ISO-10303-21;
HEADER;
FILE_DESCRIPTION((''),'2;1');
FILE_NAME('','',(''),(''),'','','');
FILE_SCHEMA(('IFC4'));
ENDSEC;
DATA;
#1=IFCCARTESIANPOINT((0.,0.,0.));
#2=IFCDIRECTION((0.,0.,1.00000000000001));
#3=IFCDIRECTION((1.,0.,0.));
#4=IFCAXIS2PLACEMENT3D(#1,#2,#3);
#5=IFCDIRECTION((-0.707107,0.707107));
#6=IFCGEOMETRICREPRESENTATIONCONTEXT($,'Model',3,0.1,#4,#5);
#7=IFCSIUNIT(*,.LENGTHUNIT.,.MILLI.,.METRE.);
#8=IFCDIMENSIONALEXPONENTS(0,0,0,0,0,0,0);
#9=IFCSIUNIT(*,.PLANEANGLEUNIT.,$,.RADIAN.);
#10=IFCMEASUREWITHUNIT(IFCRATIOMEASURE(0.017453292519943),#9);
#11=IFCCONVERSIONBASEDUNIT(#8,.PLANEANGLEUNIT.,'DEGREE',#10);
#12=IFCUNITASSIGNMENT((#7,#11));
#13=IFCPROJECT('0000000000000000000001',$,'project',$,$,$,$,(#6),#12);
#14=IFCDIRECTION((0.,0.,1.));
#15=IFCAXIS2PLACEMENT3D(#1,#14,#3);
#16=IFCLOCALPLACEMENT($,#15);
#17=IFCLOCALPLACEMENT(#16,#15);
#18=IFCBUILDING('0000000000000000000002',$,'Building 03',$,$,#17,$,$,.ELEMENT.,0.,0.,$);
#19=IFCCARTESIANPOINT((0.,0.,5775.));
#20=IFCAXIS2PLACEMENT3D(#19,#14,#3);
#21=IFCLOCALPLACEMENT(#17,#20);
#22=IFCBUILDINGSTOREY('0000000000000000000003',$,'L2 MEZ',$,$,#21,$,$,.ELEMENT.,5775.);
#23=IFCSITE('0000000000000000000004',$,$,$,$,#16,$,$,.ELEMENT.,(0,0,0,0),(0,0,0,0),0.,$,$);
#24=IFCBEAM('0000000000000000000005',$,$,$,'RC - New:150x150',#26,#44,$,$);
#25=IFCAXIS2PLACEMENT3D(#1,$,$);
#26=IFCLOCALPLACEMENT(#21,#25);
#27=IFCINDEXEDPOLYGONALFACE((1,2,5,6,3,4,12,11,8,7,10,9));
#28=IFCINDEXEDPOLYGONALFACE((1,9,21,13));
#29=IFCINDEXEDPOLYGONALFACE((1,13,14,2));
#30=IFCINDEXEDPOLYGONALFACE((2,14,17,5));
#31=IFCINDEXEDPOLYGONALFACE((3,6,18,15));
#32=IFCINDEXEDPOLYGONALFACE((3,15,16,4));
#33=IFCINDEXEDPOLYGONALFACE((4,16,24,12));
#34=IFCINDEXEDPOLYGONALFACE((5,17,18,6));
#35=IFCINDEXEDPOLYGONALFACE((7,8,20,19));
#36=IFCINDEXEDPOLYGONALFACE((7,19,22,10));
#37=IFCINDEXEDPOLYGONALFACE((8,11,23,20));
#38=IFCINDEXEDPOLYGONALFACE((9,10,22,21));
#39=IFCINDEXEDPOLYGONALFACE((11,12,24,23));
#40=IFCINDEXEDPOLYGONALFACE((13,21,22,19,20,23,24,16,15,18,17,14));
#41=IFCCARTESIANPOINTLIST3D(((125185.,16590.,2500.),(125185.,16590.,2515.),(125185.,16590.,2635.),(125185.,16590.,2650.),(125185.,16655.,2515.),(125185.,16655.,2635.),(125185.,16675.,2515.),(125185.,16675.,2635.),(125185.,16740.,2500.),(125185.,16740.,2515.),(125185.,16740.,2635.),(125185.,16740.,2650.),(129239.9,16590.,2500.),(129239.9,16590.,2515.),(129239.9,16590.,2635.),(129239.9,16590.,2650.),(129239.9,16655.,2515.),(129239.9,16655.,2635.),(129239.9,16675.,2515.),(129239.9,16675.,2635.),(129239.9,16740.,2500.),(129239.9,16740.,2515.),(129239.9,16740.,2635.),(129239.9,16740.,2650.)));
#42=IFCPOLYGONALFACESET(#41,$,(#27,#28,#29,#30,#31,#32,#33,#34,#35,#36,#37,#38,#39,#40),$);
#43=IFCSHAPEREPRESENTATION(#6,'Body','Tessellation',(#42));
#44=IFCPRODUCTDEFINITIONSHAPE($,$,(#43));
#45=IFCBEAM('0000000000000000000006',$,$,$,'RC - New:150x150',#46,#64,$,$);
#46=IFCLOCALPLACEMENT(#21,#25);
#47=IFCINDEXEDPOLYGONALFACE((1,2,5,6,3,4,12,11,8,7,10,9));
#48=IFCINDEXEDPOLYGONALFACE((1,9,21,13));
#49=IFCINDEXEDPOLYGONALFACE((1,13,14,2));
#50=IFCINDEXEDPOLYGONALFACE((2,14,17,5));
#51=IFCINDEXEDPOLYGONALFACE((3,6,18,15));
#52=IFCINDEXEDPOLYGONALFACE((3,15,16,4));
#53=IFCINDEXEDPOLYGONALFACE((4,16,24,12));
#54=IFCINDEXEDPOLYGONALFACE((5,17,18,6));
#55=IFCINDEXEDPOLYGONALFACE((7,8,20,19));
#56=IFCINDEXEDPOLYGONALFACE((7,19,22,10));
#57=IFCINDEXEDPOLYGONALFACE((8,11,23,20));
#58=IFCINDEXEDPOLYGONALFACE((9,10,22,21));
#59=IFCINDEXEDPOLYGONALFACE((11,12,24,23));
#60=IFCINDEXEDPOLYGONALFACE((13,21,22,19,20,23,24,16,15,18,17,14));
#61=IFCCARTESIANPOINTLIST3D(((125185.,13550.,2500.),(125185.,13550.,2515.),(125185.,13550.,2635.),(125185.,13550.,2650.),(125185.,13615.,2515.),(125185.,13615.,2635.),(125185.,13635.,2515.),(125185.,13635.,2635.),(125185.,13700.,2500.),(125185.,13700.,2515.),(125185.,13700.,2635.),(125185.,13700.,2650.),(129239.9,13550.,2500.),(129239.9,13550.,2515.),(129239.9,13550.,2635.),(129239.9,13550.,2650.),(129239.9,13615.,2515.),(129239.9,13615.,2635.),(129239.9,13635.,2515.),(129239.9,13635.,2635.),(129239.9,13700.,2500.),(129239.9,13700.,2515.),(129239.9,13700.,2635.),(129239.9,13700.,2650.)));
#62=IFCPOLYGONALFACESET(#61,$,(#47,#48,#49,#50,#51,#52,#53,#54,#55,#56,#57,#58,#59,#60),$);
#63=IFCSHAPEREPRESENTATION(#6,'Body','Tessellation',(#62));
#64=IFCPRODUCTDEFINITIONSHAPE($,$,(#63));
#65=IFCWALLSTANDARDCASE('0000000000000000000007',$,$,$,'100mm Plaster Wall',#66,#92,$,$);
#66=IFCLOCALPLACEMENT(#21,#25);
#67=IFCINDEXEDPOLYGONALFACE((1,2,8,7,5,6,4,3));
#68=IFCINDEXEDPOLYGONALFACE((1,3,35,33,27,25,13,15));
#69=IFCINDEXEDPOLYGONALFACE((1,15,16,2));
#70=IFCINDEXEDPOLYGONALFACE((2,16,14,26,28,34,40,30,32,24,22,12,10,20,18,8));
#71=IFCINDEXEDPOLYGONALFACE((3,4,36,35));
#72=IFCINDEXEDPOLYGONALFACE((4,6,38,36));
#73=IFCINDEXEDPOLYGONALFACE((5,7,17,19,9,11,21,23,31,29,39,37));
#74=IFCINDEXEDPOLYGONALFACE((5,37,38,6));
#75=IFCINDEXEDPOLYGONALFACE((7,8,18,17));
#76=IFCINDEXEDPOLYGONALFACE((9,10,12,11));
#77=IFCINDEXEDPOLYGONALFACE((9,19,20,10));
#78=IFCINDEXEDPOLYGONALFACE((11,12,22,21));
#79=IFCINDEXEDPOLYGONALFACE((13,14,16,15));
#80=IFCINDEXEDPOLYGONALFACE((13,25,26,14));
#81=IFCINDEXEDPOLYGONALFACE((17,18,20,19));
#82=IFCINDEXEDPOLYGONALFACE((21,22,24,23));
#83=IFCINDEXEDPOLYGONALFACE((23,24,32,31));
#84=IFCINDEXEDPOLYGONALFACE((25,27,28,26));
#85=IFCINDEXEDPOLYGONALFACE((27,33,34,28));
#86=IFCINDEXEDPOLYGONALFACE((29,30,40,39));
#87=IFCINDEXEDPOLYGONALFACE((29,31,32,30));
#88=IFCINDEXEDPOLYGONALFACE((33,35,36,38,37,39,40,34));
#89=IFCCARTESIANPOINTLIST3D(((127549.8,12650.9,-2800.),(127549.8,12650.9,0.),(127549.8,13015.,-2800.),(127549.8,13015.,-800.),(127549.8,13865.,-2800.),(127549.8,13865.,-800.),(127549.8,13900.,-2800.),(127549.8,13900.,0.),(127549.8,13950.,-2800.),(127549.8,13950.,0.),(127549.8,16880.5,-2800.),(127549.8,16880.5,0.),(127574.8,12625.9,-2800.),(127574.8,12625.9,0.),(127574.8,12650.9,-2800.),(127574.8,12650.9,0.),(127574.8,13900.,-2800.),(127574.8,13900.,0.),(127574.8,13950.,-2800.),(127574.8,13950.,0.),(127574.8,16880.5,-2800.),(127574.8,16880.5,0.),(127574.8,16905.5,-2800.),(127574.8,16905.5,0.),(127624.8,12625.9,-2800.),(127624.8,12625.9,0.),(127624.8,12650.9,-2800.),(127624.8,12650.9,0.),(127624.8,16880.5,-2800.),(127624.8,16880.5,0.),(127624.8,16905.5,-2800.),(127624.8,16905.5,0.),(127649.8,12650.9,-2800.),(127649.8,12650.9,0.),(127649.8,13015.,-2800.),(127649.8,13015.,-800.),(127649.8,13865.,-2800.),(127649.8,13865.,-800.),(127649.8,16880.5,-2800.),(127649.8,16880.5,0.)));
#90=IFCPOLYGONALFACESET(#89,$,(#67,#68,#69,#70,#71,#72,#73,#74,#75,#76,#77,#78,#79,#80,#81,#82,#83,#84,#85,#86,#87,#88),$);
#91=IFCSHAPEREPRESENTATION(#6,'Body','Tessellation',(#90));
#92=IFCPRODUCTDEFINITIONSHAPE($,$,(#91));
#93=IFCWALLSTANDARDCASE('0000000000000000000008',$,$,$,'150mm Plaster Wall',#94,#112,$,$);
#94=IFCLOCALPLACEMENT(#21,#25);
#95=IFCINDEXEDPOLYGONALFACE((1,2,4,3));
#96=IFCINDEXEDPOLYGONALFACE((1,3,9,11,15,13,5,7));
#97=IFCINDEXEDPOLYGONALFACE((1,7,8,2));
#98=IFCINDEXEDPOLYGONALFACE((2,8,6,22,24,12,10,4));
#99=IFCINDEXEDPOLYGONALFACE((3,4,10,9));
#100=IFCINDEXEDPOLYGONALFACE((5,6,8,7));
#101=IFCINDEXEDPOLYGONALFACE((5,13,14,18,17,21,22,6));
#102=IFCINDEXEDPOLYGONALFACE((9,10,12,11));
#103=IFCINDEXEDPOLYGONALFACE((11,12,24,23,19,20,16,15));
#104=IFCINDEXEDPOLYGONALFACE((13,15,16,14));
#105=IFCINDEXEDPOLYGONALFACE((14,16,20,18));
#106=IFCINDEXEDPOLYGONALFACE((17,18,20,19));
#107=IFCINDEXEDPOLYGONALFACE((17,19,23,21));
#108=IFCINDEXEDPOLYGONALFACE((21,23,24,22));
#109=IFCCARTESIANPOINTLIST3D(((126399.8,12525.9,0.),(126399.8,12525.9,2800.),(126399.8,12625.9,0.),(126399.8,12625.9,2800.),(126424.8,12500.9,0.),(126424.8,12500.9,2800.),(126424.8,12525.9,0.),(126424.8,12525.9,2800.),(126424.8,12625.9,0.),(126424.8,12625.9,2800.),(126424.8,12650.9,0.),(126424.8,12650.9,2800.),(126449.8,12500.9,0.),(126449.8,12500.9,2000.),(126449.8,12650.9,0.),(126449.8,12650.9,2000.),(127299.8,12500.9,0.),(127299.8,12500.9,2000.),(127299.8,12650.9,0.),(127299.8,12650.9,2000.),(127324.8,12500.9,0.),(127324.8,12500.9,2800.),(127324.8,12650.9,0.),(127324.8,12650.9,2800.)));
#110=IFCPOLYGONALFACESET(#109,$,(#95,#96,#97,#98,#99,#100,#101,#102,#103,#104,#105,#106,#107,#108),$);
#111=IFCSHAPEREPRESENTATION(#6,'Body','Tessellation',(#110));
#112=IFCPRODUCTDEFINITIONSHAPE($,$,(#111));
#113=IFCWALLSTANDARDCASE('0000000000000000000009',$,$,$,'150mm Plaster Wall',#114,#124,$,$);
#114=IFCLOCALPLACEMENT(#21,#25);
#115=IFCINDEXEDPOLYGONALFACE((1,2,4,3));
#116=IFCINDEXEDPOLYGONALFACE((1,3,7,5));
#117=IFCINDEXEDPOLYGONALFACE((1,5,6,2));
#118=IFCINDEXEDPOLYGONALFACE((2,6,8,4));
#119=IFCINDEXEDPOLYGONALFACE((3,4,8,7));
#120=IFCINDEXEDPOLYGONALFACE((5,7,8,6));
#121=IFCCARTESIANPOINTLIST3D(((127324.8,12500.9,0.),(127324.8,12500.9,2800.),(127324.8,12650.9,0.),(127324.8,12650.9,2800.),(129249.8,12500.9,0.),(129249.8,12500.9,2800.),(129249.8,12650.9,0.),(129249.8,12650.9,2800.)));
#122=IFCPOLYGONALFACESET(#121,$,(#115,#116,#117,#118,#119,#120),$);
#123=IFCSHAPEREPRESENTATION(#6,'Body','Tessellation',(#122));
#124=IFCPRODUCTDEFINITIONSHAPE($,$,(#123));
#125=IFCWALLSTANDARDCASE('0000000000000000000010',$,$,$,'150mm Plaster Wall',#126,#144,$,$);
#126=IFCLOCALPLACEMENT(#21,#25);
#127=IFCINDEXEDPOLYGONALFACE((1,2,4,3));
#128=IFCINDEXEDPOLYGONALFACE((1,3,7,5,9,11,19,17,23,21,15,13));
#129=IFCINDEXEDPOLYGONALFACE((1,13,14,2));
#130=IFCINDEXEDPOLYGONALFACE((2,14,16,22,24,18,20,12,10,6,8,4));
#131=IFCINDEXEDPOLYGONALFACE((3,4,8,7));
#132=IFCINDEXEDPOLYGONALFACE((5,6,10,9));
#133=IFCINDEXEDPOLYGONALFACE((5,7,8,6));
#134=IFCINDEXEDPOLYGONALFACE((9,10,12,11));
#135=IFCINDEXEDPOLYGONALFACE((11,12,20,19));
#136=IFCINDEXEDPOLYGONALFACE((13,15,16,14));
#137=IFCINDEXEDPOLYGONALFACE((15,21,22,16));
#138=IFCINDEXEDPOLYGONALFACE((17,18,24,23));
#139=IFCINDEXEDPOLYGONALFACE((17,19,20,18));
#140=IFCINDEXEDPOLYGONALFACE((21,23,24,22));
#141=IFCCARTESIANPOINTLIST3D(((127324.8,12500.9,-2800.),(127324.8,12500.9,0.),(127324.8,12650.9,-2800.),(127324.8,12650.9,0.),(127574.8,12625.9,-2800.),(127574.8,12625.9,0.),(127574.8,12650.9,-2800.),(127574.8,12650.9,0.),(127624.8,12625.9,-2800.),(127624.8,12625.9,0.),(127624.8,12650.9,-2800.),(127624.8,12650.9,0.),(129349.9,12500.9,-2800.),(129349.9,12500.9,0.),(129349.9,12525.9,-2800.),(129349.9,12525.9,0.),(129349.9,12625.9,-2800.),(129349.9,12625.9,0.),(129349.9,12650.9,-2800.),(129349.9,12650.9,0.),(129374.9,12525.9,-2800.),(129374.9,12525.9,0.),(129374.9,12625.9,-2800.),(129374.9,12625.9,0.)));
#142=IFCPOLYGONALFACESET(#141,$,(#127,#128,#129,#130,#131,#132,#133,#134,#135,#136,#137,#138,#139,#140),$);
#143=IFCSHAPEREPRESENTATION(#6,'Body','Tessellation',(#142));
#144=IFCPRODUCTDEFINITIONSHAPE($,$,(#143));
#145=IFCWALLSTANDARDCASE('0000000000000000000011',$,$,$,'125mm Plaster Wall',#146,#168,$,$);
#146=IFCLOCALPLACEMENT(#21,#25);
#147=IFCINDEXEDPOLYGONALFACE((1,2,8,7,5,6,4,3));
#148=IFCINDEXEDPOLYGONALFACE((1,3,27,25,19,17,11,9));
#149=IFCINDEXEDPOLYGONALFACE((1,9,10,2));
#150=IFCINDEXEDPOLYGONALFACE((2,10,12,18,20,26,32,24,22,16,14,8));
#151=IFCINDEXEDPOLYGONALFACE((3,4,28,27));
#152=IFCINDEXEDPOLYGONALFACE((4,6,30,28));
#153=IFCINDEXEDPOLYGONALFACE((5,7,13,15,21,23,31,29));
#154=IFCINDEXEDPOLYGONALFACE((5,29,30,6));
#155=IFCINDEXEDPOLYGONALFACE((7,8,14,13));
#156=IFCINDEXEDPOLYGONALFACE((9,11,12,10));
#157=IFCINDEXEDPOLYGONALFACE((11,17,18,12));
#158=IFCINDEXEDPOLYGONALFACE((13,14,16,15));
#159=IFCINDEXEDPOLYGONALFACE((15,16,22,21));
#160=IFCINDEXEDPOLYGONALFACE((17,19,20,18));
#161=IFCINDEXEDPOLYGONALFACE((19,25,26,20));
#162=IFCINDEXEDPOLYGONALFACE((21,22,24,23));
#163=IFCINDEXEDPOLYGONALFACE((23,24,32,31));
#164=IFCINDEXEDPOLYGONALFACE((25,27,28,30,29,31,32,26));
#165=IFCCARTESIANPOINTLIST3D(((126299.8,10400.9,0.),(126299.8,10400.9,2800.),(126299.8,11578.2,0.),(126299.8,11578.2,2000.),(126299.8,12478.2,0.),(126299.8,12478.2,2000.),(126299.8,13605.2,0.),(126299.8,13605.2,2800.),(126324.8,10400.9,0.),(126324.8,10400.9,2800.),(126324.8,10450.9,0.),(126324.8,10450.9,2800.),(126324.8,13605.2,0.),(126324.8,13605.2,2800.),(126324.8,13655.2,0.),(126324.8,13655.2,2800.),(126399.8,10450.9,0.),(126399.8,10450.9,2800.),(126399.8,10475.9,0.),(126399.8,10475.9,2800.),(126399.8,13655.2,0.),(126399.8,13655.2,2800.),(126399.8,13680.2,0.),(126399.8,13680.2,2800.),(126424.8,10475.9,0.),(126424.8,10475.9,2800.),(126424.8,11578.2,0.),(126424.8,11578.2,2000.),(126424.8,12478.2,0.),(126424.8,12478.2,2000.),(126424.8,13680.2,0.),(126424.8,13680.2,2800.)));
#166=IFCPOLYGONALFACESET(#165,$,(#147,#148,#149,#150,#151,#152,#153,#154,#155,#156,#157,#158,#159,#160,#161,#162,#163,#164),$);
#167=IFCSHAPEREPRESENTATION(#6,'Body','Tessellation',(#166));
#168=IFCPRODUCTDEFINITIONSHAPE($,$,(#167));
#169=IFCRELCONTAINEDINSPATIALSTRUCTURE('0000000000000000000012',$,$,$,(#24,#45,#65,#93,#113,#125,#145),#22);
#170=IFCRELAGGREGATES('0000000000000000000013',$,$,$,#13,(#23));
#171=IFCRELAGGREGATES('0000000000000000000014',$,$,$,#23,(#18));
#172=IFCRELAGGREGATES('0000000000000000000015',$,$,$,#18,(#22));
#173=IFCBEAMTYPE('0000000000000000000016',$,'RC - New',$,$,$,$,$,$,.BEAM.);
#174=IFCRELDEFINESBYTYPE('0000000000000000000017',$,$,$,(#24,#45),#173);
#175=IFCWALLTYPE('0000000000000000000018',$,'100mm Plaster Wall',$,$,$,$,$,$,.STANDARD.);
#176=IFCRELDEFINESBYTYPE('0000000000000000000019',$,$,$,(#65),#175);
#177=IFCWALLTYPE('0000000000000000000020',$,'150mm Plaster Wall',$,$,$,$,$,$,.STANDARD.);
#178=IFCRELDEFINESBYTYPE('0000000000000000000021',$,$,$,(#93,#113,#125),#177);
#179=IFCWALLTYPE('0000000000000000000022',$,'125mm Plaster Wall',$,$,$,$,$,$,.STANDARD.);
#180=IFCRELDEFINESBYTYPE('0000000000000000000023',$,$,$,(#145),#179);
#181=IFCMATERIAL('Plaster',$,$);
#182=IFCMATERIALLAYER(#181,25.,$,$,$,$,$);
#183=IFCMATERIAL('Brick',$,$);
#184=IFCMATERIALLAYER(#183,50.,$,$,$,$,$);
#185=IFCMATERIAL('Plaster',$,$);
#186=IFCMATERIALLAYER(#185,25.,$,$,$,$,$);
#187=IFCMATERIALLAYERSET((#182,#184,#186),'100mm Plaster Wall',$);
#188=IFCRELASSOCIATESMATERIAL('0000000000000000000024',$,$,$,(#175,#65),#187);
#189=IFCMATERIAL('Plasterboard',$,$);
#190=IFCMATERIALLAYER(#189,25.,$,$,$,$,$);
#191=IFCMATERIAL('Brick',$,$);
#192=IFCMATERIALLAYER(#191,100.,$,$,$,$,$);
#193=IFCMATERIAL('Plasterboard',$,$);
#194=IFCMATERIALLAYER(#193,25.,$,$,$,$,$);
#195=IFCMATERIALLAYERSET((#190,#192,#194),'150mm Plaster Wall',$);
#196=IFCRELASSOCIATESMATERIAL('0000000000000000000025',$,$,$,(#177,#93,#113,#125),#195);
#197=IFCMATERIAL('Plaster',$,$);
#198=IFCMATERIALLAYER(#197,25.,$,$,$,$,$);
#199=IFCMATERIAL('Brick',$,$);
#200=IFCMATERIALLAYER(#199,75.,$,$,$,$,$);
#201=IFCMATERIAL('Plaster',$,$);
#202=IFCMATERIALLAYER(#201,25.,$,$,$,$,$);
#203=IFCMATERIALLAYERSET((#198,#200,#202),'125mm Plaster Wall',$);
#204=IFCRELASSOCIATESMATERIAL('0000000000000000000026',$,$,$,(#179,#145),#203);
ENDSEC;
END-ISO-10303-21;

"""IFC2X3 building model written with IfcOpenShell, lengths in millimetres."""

from ifc_helpers import new_model, entity, si_unit, converted_unit, direction, frame, origin_with_axes, origin_2d, place, context, project, spatial, polyline, rectangle, i_section, outline, extrude, material, layer, layer_set, layer_usage, type_object, element, save


model = new_model("IFC2X3")

# Units and contexts
model_context = context("Model", 3, precision=0.1, world=frame((0.0, 0.0, 0.0), z_axis=(0.0, 0.0, 1.00000000000001), x_axis=(1.0, 0.0, 0.0)), true_north=direction((-0.707107, 0.707107)))
ifc_project = project(units=[si_unit("LENGTHUNIT", "METRE", prefix="MILLI"), converted_unit("PLANEANGLEUNIT", "DEGREE", entity("IfcRatioMeasure", 0.017453292519943), si_unit("PLANEANGLEUNIT", "RADIAN"), dimensions=[0, 0, 0, 0, 0, 0, 0])], contexts=[model_context])

# Site, building, storey
site_placement = place(None, origin_with_axes())
site = spatial("IfcSite", under=ifc_project, at=site_placement, CompositionType="ELEMENT", RefLatitude=(0, 0, 0, 0), RefLongitude=(0, 0, 0, 0), RefElevation=0.0)
building_placement = place(site_placement, origin_with_axes())
building = spatial("IfcBuilding", under=site, at=building_placement, Name="Building 03", CompositionType="ELEMENT", ElevationOfRefHeight=0.0, ElevationOfTerrain=0.0)
storey_placement = place(building_placement, frame((0.0, 0.0, 5775.0), z_axis=(0.0, 0.0, 1.0), x_axis=(1.0, 0.0, 0.0)))
storey = spatial("IfcBuildingStorey", under=building, at=storey_placement, Name="L2 MEZ", CompositionType="ELEMENT", Elevation=5775.0)

# Beams
beam_type = type_object("IfcBeamType", Name="RC - New", PredefinedType="BEAM")
for number, where, z_axis, x_axis in (
    (1, (125185.0, 16665.0, 8350.0), (1.0, 0.0, 0.0), (0.0, 1.0, 0.0)),
    (2, (125185.0, 13625.0, 8350.0), (1.0, 0.0, 0.0), (0.0, 1.0, 0.0)),
):
    element("IfcBeam", number, at=place(site_placement, frame(where, z_axis=z_axis, x_axis=x_axis)), inside=storey, type_object=beam_type, ObjectType="RC - New:150x150", context=model_context, shape_type="SweptSolid", body=[
        extrude(i_section(OverallWidth=150.0, OverallDepth=150.0, WebThickness=20.0, FlangeThickness=15.0, at=origin_2d()), frame((0.0, 0.0, 0.0), z_axis=(0.0, 0.0, 1.0), x_axis=(1.0, 0.0, 0.0)), (0.0, 0.0, 1.0), 4054.9),
    ])

# Wall, opening
ifc_material_1 = material(Name="Plaster")
ifc_layer_1 = layer(ifc_material_1, 25.0)
ifc_material_2 = material(Name="Brick")
ifc_layer_2 = layer(ifc_material_2, 50.0)
ifc_material_3 = material(Name="Plaster")
ifc_layer_3 = layer(ifc_material_3, 25.0)
ifc_layer_set_1 = layer_set([ifc_layer_1, ifc_layer_2, ifc_layer_3], Name="100mm Plaster Wall")
ifc_layer_usage_1 = layer_usage(ifc_layer_set_1, "AXIS2", "POSITIVE", -50.0)
wall_type_1 = type_object("IfcWallType", Name="100mm Plaster Wall", PredefinedType="STANDARD", material=ifc_layer_set_1)
wall_1_placement = place(site_placement, frame((127599.8, 12650.9, 2975.0), z_axis=(0.0, 0.0, 1.0), x_axis=(0.0, 1.0, 0.0)))
wall_1 = element("IfcWallStandardCase", 3, at=wall_1_placement, inside=storey, type_object=wall_type_1, material=ifc_layer_usage_1, ObjectType="100mm Plaster Wall", context=model_context, shape_type="SweptSolid", body=[
    extrude(outline(polyline([(1249.1, 50.0), (1249.1, 25.0), (1299.1, 25.0), (1299.1, 50.0), (4229.6, 50.0), (4229.7, 25.0), (4254.7, 25.0), (4254.7, -25.0), (4229.7, -25.0), (4229.7, -50.0), (0.0, -50.0), (0.0, -25.0), (-25.0, -25.0), (-25.0, 25.0), (0.0, 25.0), (0.0, 50.0), (1249.1, 50.0)])), origin_with_axes(), (0.0, 0.0, 1.0), 2800.0),
])
opening_1_placement = place(wall_1_placement, frame((789.1, 0.0, 0.0), z_axis=(0.0, 0.0, 1.0), x_axis=(1.0, 0.0, 0.0)))
element("IfcOpeningElement", 4, at=opening_1_placement, cuts=wall_1, ObjectType="Opening", context=model_context, shape_type="SweptSolid", body=[
    extrude(rectangle(XDim=850.0, YDim=2000.0, at=origin_2d()), frame((0.0, 750.0, 1000.0), z_axis=(0.0, -1.0, 0.0), x_axis=(1.0, 0.0, 0.0)), (0.0, 0.0, 1.0), 1500.0),
])

# Wall, opening
ifc_material_4 = material(Name="Plasterboard")
ifc_layer_4 = layer(ifc_material_4, 25.0)
ifc_material_5 = material(Name="Brick")
ifc_layer_5 = layer(ifc_material_5, 100.0)
ifc_material_6 = material(Name="Plasterboard")
ifc_layer_6 = layer(ifc_material_6, 25.0)
ifc_layer_set_2 = layer_set([ifc_layer_4, ifc_layer_5, ifc_layer_6], Name="150mm Plaster Wall")
ifc_layer_usage_2 = layer_usage(ifc_layer_set_2, "AXIS2", "POSITIVE", -75.0)
wall_type_2 = type_object("IfcWallType", Name="150mm Plaster Wall", PredefinedType="STANDARD", material=ifc_layer_set_2)
wall_2_placement = place(site_placement, frame((127324.8, 12575.9, 5775.0), z_axis=(0.0, 0.0, 1.0), x_axis=(-1.0, 0.0, 0.0)))
wall_2 = element("IfcWallStandardCase", 5, at=wall_2_placement, inside=storey, type_object=wall_type_2, material=ifc_layer_usage_2, ObjectType="150mm Plaster Wall", context=model_context, shape_type="SweptSolid", body=[
    extrude(outline(polyline([(900.0, 50.0), (900.0, 75.0), (0.0, 75.0), (0.0, -75.0), (900.0, -75.0), (900.0, -50.0), (925.0, -50.0), (925.0, 50.0), (900.0, 50.0)])), origin_with_axes(), (0.0, 0.0, 1.0), 2800.0),
])
opening_2_placement = place(wall_2_placement, frame((450.0, 0.0, 0.0), z_axis=(0.0, 0.0, 1.0), x_axis=(-1.0, 0.0, 0.0)))
element("IfcOpeningElement", 6, at=opening_2_placement, cuts=wall_2, ObjectType="Opening", context=model_context, shape_type="SweptSolid", body=[
    extrude(rectangle(XDim=850.0, YDim=2000.0, at=origin_2d()), frame((0.0, 750.0, 1000.0), z_axis=(0.0, -1.0, 0.0), x_axis=(1.0, 0.0, 0.0)), (0.0, 0.0, 1.0), 1500.0),
])

# Wall
wall_3_placement = place(site_placement, frame((127324.8, 12575.9, 5775.0), z_axis=(0.0, 0.0, 1.0), x_axis=(1.0, 0.0, 0.0)))
element("IfcWallStandardCase", 7, at=wall_3_placement, inside=storey, type_object=wall_type_2, material=ifc_layer_usage_2, ObjectType="150mm Plaster Wall", context=model_context, shape_type="SweptSolid", body=[
    extrude(outline(polyline([(1925.0, 75.0), (1925.0, -75.0), (0.0, -75.0), (0.0, 75.0), (1925.0, 75.0)])), origin_with_axes(), (0.0, 0.0, 1.0), 2800.0),
])

# Wall
wall_4_placement = place(site_placement, frame((127324.8, 12575.9, 2975.0), z_axis=(0.0, 0.0, 1.0), x_axis=(1.0, 0.0, 0.0)))
element("IfcWallStandardCase", 8, at=wall_4_placement, inside=storey, type_object=wall_type_2, material=ifc_layer_usage_2, ObjectType="150mm Plaster Wall", context=model_context, shape_type="SweptSolid", body=[
    extrude(outline(polyline([(250.0, 75.0), (250.0, 50.0), (300.0, 50.0), (300.0, 75.0), (2025.1, 75.0), (2025.1, 50.0), (2050.1, 50.0), (2050.1, -50.0), (2025.1, -50.0), (2025.1, -75.0), (0.0, -75.0), (0.0, 75.0), (250.0, 75.0)])), origin_with_axes(), (0.0, 0.0, 1.0), 2800.0),
])

# Wall, opening
ifc_material_7 = material(Name="Plaster")
ifc_layer_7 = layer(ifc_material_7, 25.0)
ifc_material_8 = material(Name="Brick")
ifc_layer_8 = layer(ifc_material_8, 75.0)
ifc_material_9 = material(Name="Plaster")
ifc_layer_9 = layer(ifc_material_9, 25.0)
ifc_layer_set_3 = layer_set([ifc_layer_7, ifc_layer_8, ifc_layer_9], Name="125mm Plaster Wall")
ifc_layer_usage_3 = layer_usage(ifc_layer_set_3, "AXIS2", "POSITIVE", -62.5)
wall_type_3 = type_object("IfcWallType", Name="125mm Plaster Wall", PredefinedType="STANDARD", material=ifc_layer_set_3)
wall_5_placement = place(site_placement, frame((126362.3, 13680.2, 5775.0), z_axis=(0.0, 0.0, 1.0), x_axis=(0.0, -1.0, 0.0)))
wall_5 = element("IfcWallStandardCase", 9, at=wall_5_placement, inside=storey, type_object=wall_type_3, material=ifc_layer_usage_3, ObjectType="125mm Plaster Wall", context=model_context, shape_type="SweptSolid", body=[
    extrude(outline(polyline([(3204.3, 62.5), (3204.3, 37.5), (3229.3, 37.5), (3229.3, -37.5), (3279.3, -37.5), (3279.3, -62.5), (75.0, -62.5), (75.0, -37.5), (25.0, -37.5), (25.0, 37.5), (0.0, 37.5), (0.0, 62.5), (3204.3, 62.5)])), origin_with_axes(), (0.0, 0.0, 1.0), 2800.0),
])
opening_3_placement = place(wall_5_placement, frame((1652.0, 0.0, 0.0), z_axis=(0.0, 0.0, 1.0), x_axis=(1.0, 0.0, 0.0)))
element("IfcOpeningElement", 10, at=opening_3_placement, cuts=wall_5, ObjectType="Opening", context=model_context, shape_type="SweptSolid", body=[
    extrude(rectangle(XDim=900.0, YDim=2000.0, at=origin_2d()), frame((0.0, 800.0, 1000.0), z_axis=(0.0, -1.0, 0.0), x_axis=(1.0, 0.0, 0.0)), (0.0, 0.0, 1.0), 1600.0),
])

save(model, "model.ifc")
